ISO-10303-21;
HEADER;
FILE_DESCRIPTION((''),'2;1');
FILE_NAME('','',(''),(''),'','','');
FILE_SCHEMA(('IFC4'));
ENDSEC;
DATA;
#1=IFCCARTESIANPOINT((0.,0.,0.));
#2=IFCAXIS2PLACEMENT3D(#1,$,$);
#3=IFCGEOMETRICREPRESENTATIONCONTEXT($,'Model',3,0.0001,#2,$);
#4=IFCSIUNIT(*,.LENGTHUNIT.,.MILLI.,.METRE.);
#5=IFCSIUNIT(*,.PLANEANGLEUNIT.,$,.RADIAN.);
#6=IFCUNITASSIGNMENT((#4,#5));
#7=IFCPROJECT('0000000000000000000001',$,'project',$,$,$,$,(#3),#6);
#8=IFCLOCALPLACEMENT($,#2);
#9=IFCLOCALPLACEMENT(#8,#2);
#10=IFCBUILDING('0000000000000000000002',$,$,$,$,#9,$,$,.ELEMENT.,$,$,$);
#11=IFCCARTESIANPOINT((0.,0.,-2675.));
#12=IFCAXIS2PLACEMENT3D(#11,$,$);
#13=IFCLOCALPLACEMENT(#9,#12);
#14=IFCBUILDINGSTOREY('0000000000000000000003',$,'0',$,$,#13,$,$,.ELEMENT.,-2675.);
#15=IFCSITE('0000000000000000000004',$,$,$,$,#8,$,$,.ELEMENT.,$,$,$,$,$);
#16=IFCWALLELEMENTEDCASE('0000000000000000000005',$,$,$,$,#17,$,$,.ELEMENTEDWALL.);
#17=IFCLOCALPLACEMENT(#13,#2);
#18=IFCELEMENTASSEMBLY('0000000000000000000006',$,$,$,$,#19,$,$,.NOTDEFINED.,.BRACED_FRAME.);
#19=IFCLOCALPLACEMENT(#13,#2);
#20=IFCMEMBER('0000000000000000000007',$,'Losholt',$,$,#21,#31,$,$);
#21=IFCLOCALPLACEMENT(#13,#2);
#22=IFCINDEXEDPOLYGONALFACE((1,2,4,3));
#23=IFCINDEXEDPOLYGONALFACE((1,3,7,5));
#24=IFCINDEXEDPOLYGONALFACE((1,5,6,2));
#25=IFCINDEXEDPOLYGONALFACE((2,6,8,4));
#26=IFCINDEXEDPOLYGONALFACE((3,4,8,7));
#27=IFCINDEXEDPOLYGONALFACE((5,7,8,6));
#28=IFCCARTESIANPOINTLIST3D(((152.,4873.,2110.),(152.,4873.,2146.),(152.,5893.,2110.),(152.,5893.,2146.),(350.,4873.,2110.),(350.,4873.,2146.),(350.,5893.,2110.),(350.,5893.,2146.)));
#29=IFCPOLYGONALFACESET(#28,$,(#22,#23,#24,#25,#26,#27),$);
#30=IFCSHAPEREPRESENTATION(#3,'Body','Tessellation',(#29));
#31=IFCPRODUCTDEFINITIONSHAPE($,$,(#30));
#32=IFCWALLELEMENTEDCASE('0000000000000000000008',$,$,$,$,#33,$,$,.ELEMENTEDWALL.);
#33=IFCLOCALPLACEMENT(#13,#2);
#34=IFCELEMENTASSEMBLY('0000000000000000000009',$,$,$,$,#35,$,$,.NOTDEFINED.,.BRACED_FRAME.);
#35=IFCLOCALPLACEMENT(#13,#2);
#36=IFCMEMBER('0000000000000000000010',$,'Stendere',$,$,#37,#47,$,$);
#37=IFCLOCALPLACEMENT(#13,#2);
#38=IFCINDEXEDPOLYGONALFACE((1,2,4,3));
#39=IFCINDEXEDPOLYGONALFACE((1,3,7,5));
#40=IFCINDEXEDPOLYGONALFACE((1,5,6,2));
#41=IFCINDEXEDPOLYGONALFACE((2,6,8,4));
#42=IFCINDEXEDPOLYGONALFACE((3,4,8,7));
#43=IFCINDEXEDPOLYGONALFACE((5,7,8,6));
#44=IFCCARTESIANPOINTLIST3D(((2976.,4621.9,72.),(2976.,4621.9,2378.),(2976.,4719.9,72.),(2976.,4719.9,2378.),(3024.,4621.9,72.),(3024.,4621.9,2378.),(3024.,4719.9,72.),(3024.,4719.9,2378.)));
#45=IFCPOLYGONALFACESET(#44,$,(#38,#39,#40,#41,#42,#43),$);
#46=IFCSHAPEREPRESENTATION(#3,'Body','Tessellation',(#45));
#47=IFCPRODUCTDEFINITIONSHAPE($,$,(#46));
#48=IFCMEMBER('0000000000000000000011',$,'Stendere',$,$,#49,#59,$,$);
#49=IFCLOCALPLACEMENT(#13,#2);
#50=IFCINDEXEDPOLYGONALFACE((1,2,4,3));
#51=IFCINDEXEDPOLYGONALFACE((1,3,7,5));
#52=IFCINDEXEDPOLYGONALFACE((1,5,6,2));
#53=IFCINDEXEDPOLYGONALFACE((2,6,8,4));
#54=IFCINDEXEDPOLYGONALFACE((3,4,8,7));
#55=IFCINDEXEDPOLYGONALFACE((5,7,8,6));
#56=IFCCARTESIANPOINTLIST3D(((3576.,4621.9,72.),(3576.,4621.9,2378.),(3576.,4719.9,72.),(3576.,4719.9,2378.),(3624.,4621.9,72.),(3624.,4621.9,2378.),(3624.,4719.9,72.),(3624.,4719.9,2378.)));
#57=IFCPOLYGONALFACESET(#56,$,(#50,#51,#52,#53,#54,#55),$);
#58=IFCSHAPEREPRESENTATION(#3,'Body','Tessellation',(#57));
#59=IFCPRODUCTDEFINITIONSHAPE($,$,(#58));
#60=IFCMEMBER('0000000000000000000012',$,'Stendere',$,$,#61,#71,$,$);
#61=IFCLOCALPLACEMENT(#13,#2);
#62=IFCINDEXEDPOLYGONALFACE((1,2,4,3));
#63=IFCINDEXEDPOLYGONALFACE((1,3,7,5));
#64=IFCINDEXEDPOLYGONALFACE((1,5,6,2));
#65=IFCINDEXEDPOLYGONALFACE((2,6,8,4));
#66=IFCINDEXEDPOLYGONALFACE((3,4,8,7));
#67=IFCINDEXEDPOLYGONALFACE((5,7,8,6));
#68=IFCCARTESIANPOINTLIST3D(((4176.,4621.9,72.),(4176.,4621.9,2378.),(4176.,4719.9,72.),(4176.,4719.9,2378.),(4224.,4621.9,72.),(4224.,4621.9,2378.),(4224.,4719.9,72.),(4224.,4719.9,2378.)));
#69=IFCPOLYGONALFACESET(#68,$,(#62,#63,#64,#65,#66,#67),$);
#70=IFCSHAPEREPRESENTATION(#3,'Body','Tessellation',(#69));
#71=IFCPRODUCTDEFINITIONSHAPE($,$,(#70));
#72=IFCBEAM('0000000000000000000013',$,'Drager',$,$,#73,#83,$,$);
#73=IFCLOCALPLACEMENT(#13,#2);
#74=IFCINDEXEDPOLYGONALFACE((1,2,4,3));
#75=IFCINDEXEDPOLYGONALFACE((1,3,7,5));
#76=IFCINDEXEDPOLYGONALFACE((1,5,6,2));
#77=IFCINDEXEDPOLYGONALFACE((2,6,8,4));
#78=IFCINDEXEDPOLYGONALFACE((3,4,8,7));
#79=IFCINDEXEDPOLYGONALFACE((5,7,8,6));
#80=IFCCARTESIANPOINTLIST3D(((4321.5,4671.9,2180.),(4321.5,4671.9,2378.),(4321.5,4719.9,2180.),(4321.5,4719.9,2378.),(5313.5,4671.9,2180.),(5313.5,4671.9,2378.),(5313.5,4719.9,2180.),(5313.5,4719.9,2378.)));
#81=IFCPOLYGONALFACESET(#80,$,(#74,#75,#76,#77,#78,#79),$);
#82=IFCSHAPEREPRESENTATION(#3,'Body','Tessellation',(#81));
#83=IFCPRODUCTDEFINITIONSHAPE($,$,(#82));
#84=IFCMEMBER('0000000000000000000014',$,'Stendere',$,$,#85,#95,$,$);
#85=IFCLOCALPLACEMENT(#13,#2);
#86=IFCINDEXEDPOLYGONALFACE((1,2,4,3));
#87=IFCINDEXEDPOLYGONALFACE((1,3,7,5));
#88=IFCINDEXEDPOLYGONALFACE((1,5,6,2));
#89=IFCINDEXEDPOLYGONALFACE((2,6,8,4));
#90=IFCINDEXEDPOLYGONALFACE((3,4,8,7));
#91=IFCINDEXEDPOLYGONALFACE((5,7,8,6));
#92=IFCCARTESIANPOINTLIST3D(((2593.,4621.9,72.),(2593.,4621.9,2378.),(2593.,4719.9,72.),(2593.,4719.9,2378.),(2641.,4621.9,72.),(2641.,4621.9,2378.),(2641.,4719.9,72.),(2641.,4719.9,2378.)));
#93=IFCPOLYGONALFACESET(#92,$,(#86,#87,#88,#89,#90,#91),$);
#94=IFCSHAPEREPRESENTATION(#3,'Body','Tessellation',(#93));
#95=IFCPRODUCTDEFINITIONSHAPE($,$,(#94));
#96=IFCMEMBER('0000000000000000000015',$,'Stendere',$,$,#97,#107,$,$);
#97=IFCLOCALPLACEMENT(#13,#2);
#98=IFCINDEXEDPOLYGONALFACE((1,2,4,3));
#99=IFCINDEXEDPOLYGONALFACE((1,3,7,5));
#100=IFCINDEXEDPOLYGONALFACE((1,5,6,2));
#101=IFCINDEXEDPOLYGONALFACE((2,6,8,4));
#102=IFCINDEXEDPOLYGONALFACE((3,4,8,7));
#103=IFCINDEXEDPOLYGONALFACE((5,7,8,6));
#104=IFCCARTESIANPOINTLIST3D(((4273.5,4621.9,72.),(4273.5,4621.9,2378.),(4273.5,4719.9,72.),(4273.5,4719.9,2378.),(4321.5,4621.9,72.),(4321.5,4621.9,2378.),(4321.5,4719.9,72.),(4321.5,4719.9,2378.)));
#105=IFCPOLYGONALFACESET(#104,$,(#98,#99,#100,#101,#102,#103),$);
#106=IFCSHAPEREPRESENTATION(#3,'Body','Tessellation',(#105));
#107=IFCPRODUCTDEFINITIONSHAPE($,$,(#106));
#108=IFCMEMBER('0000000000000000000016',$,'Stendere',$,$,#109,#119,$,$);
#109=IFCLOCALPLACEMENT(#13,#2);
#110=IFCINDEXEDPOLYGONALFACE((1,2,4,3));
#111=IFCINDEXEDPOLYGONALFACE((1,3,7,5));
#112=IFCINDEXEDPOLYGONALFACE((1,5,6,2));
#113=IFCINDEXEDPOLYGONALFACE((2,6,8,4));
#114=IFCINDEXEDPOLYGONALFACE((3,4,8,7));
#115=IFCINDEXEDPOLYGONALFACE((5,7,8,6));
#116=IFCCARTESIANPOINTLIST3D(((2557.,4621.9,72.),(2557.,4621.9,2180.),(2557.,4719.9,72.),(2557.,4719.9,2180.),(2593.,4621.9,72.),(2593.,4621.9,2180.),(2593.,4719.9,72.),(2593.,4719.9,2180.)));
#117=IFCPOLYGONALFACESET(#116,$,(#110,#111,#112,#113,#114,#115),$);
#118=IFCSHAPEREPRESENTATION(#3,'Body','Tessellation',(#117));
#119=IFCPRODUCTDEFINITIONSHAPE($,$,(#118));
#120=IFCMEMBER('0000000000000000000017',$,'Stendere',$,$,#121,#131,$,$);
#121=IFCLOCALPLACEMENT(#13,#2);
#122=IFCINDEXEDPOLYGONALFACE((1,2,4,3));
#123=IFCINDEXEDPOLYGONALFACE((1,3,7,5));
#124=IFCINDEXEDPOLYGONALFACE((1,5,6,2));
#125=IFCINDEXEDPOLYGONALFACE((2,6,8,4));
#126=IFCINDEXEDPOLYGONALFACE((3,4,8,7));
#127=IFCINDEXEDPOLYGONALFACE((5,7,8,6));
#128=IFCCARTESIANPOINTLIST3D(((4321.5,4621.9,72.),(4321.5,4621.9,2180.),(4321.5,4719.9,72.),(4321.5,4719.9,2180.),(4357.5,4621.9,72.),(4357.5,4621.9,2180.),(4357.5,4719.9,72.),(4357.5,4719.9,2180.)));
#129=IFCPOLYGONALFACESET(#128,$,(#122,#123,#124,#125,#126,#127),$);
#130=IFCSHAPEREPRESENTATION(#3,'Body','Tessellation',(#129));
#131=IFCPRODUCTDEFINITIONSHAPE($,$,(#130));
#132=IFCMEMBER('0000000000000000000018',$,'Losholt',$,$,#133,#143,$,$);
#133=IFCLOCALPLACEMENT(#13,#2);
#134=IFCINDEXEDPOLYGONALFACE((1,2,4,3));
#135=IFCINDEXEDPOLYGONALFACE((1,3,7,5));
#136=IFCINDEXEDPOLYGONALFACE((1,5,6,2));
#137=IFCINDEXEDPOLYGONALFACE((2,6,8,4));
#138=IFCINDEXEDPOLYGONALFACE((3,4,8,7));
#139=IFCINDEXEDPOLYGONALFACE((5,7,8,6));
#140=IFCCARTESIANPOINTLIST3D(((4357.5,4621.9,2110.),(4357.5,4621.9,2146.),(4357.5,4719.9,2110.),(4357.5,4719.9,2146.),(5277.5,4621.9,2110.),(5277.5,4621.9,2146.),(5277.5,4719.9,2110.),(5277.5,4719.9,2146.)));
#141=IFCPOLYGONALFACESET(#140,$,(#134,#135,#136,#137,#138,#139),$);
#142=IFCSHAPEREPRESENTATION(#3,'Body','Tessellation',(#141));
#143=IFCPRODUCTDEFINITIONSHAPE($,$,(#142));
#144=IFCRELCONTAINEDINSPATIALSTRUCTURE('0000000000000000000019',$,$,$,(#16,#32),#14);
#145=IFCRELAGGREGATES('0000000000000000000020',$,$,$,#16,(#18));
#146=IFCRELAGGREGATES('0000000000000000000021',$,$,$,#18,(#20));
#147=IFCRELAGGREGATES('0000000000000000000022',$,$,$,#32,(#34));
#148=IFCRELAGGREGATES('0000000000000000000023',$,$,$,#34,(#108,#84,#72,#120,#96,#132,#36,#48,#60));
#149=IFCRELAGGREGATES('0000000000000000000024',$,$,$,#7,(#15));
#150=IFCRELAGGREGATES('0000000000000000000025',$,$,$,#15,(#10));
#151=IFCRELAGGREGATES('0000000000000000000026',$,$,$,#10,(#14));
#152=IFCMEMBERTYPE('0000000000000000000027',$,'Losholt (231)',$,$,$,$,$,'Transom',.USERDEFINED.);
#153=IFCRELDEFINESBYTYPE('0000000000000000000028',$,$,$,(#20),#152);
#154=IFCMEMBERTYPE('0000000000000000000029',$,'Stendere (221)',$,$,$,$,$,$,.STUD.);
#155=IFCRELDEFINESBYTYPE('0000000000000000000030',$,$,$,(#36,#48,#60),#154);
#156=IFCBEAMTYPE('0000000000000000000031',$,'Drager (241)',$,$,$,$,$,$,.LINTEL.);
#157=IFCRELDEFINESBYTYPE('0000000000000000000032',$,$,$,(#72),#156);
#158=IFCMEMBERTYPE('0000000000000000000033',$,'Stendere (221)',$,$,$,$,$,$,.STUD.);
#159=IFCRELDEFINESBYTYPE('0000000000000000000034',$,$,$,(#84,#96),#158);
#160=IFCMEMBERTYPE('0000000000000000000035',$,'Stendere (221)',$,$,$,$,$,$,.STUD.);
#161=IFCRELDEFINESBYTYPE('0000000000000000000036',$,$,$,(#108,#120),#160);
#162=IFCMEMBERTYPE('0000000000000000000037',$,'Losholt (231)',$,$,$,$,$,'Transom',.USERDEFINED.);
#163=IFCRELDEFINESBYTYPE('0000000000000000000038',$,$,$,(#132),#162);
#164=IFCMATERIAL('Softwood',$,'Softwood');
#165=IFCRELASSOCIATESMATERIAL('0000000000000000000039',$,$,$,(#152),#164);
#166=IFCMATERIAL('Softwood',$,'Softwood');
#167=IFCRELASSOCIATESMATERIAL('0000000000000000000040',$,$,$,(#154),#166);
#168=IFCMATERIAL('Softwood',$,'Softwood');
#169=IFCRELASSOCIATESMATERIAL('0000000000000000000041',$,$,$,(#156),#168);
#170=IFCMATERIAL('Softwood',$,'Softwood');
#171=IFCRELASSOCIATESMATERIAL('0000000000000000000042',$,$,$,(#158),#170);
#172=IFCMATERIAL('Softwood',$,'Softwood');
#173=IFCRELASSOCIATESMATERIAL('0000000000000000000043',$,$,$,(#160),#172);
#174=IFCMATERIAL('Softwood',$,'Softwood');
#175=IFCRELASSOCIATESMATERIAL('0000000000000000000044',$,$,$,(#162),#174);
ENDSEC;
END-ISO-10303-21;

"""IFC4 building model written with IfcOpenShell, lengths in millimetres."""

from ifc_helpers import new_model, si_unit, frame, origin, place, context, project, spatial, rectangle, extrude, clip, halfspace, material, material_profile, profile_set, type_object, element, aggregate, save


model = new_model("IFC4")

# Units and contexts
model_context = context("Model", 3, precision=0.0001, world=origin())
ifc_project = project(units=[si_unit("LENGTHUNIT", "METRE", prefix="MILLI"), si_unit("PLANEANGLEUNIT", "RADIAN")], contexts=[model_context])

# Site, building, storey
site_placement = place(None, origin())
site = spatial("IfcSite", under=ifc_project, at=site_placement, CompositionType="ELEMENT")
building_placement = place(site_placement, origin())
building = spatial("IfcBuilding", under=site, at=building_placement, CompositionType="ELEMENT")
storey_placement = place(building_placement, frame((0.0, 0.0, -2675.0)))
storey = spatial("IfcBuildingStorey", under=building, at=storey_placement, Name="0", CompositionType="ELEMENT", Elevation=-2675.0)

# Wall, element assembly
wall_1_placement = place(storey_placement, frame((350.0, 6150.0, 0.0), z_axis=(-1.0, 0.0, 0.0), x_axis=(0.0, -1.0, 0.0)))
wall_1 = element("IfcWallElementedCase", 1, at=wall_1_placement, inside=storey, PredefinedType="ELEMENTEDWALL")
assembly_1_placement = place(wall_1_placement, origin())
assembly_1 = element("IfcElementAssembly", 2, at=assembly_1_placement, AssemblyPlace="NOTDEFINED", PredefinedType="BRACED_FRAME")
aggregate(wall_1, [assembly_1])

# Member
ifc_material_1 = material(Name="Softwood", Category="Softwood")
ifc_material_profile_1 = material_profile(ifc_material_1, rectangle(XDim=36.0, YDim=198.0), Name="Losholt (231)")
ifc_profile_set_1 = profile_set([ifc_material_profile_1])
member_type_1 = type_object("IfcMemberType", Name="Losholt (231)", ElementType="Transom", PredefinedType="USERDEFINED", material=ifc_profile_set_1)
member_1_placement = place(assembly_1_placement, frame((257.0, 2128.0, 0.0), z_axis=(1.0, 0.0, 0.0), x_axis=(0.0, 1.0, 0.0)))
member_1 = element("IfcMember", 3, at=member_1_placement, type_object=member_type_1, Name="Losholt", context=model_context, shape_type="SweptSolid", body=[
    extrude(rectangle(XDim=36.0, YDim=198.0), frame((0.0, 99.0, 0.0)), (0.0, 0.0, 1.0), 1020.0),
])
aggregate(assembly_1, [member_1])

# Wall, element assembly, members, beam
wall_2_placement = place(storey_placement, frame((352.0, 4719.9, 0.0), z_axis=(0.0, -1.0, 0.0)))
wall_2 = element("IfcWallElementedCase", 4, at=wall_2_placement, inside=storey, PredefinedType="ELEMENTEDWALL")
assembly_2_placement = place(wall_2_placement, origin())
assembly_2 = element("IfcElementAssembly", 5, at=assembly_2_placement, AssemblyPlace="NOTDEFINED", PredefinedType="BRACED_FRAME")
aggregate(wall_2, [assembly_2])
ifc_material_2 = material(Name="Softwood", Category="Softwood")
ifc_material_profile_2 = material_profile(ifc_material_2, rectangle(XDim=48.0, YDim=98.0), Name="Stendere (221)")
ifc_profile_set_2 = profile_set([ifc_material_profile_2])
member_type_2 = type_object("IfcMemberType", Name="Stendere (221)", PredefinedType="STUD", material=ifc_profile_set_2)
member_2_placement = place(assembly_2_placement, frame((2648.0, 72.0, 0.0), z_axis=(0.0, 1.0, 0.0), x_axis=(-1.0, 0.0, 0.0)))
member_2 = element("IfcMember", 6, at=member_2_placement, type_object=member_type_2, Name="Stendere", context=model_context, shape_type="Clipping", body=[
    clip(extrude(rectangle(XDim=48.0, YDim=98.0), frame((0.0, 49.0, 0.0)), (0.0, 0.0, 1.0), 2306.0), halfspace(frame((0.0, 49.0, 0.0)), True)),
])
member_3_placement = place(assembly_2_placement, frame((3248.0, 72.0, 0.0), z_axis=(0.0, 1.0, 0.0), x_axis=(-1.0, 0.0, 0.0)))
member_3 = element("IfcMember", 7, at=member_3_placement, type_object=member_type_2, Name="Stendere", context=model_context, shape_type="SweptSolid", body=[
    extrude(rectangle(XDim=48.0, YDim=98.0), frame((0.0, 49.0, 0.0)), (0.0, 0.0, 1.0), 2306.0),
])
member_4_placement = place(assembly_2_placement, frame((3848.0, 72.0, 0.0), z_axis=(0.0, 1.0, 0.0), x_axis=(-1.0, 0.0, 0.0)))
member_4 = element("IfcMember", 8, at=member_4_placement, type_object=member_type_2, Name="Stendere", context=model_context, shape_type="SweptSolid", body=[
    extrude(rectangle(XDim=48.0, YDim=98.0), frame((0.0, 49.0, 0.0)), (0.0, 0.0, 1.0), 2306.0),
])
ifc_material_3 = material(Name="Softwood", Category="Softwood")
ifc_material_profile_3 = material_profile(ifc_material_3, rectangle(XDim=198.0, YDim=48.0), Name="Drager (241)")
ifc_profile_set_3 = profile_set([ifc_material_profile_3])
beam_type = type_object("IfcBeamType", Name="Drager (241)", PredefinedType="LINTEL", material=ifc_profile_set_3)
beam_placement = place(assembly_2_placement, frame((3969.5, 2279.0, 0.0), z_axis=(1.0, 0.0, 0.0), x_axis=(0.0, 1.0, 0.0)))
beam = element("IfcBeam", 9, at=beam_placement, type_object=beam_type, Name="Drager", context=model_context, shape_type="SweptSolid", body=[
    extrude(rectangle(XDim=198.0, YDim=48.0), frame((0.0, 24.0, 0.0)), (0.0, 0.0, 1.0), 992.0),
])

# Members
ifc_material_4 = material(Name="Softwood", Category="Softwood")
ifc_material_profile_4 = material_profile(ifc_material_4, rectangle(XDim=48.0, YDim=98.0), Name="Stendere (221)")
ifc_profile_set_4 = profile_set([ifc_material_profile_4])
member_type_3 = type_object("IfcMemberType", Name="Stendere (221)", PredefinedType="STUD", material=ifc_profile_set_4)
member_5_placement = place(assembly_2_placement, frame((2265.0, 72.0, 0.0), z_axis=(0.0, 1.0, 0.0), x_axis=(-1.0, 0.0, 0.0)))
member_5 = element("IfcMember", 10, at=member_5_placement, type_object=member_type_3, Name="Stendere", context=model_context, shape_type="SweptSolid", body=[
    extrude(rectangle(XDim=48.0, YDim=98.0), frame((0.0, 49.0, 0.0)), (0.0, 0.0, 1.0), 2306.0),
])
member_6_placement = place(assembly_2_placement, frame((3945.5, 72.0, 0.0), z_axis=(0.0, 1.0, 0.0), x_axis=(-1.0, 0.0, 0.0)))
member_6 = element("IfcMember", 11, at=member_6_placement, type_object=member_type_3, Name="Stendere", context=model_context, shape_type="Clipping", body=[
    clip(extrude(rectangle(XDim=48.0, YDim=98.0), frame((0.0, 49.0, 0.0)), (0.0, 0.0, 1.0), 2306.0), halfspace(frame((0.0, 49.0, 0.0)), True)),
])
ifc_material_5 = material(Name="Softwood", Category="Softwood")
ifc_material_profile_5 = material_profile(ifc_material_5, rectangle(XDim=36.0, YDim=98.0), Name="Stendere (221)")
ifc_profile_set_5 = profile_set([ifc_material_profile_5])
member_type_4 = type_object("IfcMemberType", Name="Stendere (221)", PredefinedType="STUD", material=ifc_profile_set_5)
member_7_placement = place(assembly_2_placement, frame((2223.0, 72.0, 0.0), z_axis=(0.0, 1.0, 0.0), x_axis=(-1.0, 0.0, 0.0)))
member_7 = element("IfcMember", 12, at=member_7_placement, type_object=member_type_4, Name="Stendere", context=model_context, shape_type="SweptSolid", body=[
    extrude(rectangle(XDim=36.0, YDim=98.0), frame((0.0, 49.0, 0.0)), (0.0, 0.0, 1.0), 2108.0),
])
member_8_placement = place(assembly_2_placement, frame((3987.5, 72.0, 0.0), z_axis=(0.0, 1.0, 0.0), x_axis=(-1.0, 0.0, 0.0)))
member_8 = element("IfcMember", 13, at=member_8_placement, type_object=member_type_4, Name="Stendere", context=model_context, shape_type="Clipping", body=[
    clip(extrude(rectangle(XDim=36.0, YDim=98.0), frame((0.0, 49.0, 0.0)), (0.0, 0.0, 1.0), 2108.0), halfspace(frame((0.0, 49.0, 0.0)), True)),
])
ifc_material_6 = material(Name="Softwood", Category="Softwood")
ifc_material_profile_6 = material_profile(ifc_material_6, rectangle(XDim=36.0, YDim=98.0), Name="Losholt (231)")
ifc_profile_set_6 = profile_set([ifc_material_profile_6])
member_type_5 = type_object("IfcMemberType", Name="Losholt (231)", ElementType="Transom", PredefinedType="USERDEFINED", material=ifc_profile_set_6)
member_9_placement = place(assembly_2_placement, frame((4005.5, 2128.0, 0.0), z_axis=(1.0, 0.0, 0.0), x_axis=(0.0, 1.0, 0.0)))
member_9 = element("IfcMember", 14, at=member_9_placement, type_object=member_type_5, Name="Losholt", context=model_context, shape_type="SweptSolid", body=[
    extrude(rectangle(XDim=36.0, YDim=98.0), frame((0.0, 49.0, 0.0)), (0.0, 0.0, 1.0), 920.0),
])
aggregate(assembly_2, [member_7, member_5, beam, member_8, member_6, member_9, member_2, member_3, member_4])

save(model, "model.ifc")
